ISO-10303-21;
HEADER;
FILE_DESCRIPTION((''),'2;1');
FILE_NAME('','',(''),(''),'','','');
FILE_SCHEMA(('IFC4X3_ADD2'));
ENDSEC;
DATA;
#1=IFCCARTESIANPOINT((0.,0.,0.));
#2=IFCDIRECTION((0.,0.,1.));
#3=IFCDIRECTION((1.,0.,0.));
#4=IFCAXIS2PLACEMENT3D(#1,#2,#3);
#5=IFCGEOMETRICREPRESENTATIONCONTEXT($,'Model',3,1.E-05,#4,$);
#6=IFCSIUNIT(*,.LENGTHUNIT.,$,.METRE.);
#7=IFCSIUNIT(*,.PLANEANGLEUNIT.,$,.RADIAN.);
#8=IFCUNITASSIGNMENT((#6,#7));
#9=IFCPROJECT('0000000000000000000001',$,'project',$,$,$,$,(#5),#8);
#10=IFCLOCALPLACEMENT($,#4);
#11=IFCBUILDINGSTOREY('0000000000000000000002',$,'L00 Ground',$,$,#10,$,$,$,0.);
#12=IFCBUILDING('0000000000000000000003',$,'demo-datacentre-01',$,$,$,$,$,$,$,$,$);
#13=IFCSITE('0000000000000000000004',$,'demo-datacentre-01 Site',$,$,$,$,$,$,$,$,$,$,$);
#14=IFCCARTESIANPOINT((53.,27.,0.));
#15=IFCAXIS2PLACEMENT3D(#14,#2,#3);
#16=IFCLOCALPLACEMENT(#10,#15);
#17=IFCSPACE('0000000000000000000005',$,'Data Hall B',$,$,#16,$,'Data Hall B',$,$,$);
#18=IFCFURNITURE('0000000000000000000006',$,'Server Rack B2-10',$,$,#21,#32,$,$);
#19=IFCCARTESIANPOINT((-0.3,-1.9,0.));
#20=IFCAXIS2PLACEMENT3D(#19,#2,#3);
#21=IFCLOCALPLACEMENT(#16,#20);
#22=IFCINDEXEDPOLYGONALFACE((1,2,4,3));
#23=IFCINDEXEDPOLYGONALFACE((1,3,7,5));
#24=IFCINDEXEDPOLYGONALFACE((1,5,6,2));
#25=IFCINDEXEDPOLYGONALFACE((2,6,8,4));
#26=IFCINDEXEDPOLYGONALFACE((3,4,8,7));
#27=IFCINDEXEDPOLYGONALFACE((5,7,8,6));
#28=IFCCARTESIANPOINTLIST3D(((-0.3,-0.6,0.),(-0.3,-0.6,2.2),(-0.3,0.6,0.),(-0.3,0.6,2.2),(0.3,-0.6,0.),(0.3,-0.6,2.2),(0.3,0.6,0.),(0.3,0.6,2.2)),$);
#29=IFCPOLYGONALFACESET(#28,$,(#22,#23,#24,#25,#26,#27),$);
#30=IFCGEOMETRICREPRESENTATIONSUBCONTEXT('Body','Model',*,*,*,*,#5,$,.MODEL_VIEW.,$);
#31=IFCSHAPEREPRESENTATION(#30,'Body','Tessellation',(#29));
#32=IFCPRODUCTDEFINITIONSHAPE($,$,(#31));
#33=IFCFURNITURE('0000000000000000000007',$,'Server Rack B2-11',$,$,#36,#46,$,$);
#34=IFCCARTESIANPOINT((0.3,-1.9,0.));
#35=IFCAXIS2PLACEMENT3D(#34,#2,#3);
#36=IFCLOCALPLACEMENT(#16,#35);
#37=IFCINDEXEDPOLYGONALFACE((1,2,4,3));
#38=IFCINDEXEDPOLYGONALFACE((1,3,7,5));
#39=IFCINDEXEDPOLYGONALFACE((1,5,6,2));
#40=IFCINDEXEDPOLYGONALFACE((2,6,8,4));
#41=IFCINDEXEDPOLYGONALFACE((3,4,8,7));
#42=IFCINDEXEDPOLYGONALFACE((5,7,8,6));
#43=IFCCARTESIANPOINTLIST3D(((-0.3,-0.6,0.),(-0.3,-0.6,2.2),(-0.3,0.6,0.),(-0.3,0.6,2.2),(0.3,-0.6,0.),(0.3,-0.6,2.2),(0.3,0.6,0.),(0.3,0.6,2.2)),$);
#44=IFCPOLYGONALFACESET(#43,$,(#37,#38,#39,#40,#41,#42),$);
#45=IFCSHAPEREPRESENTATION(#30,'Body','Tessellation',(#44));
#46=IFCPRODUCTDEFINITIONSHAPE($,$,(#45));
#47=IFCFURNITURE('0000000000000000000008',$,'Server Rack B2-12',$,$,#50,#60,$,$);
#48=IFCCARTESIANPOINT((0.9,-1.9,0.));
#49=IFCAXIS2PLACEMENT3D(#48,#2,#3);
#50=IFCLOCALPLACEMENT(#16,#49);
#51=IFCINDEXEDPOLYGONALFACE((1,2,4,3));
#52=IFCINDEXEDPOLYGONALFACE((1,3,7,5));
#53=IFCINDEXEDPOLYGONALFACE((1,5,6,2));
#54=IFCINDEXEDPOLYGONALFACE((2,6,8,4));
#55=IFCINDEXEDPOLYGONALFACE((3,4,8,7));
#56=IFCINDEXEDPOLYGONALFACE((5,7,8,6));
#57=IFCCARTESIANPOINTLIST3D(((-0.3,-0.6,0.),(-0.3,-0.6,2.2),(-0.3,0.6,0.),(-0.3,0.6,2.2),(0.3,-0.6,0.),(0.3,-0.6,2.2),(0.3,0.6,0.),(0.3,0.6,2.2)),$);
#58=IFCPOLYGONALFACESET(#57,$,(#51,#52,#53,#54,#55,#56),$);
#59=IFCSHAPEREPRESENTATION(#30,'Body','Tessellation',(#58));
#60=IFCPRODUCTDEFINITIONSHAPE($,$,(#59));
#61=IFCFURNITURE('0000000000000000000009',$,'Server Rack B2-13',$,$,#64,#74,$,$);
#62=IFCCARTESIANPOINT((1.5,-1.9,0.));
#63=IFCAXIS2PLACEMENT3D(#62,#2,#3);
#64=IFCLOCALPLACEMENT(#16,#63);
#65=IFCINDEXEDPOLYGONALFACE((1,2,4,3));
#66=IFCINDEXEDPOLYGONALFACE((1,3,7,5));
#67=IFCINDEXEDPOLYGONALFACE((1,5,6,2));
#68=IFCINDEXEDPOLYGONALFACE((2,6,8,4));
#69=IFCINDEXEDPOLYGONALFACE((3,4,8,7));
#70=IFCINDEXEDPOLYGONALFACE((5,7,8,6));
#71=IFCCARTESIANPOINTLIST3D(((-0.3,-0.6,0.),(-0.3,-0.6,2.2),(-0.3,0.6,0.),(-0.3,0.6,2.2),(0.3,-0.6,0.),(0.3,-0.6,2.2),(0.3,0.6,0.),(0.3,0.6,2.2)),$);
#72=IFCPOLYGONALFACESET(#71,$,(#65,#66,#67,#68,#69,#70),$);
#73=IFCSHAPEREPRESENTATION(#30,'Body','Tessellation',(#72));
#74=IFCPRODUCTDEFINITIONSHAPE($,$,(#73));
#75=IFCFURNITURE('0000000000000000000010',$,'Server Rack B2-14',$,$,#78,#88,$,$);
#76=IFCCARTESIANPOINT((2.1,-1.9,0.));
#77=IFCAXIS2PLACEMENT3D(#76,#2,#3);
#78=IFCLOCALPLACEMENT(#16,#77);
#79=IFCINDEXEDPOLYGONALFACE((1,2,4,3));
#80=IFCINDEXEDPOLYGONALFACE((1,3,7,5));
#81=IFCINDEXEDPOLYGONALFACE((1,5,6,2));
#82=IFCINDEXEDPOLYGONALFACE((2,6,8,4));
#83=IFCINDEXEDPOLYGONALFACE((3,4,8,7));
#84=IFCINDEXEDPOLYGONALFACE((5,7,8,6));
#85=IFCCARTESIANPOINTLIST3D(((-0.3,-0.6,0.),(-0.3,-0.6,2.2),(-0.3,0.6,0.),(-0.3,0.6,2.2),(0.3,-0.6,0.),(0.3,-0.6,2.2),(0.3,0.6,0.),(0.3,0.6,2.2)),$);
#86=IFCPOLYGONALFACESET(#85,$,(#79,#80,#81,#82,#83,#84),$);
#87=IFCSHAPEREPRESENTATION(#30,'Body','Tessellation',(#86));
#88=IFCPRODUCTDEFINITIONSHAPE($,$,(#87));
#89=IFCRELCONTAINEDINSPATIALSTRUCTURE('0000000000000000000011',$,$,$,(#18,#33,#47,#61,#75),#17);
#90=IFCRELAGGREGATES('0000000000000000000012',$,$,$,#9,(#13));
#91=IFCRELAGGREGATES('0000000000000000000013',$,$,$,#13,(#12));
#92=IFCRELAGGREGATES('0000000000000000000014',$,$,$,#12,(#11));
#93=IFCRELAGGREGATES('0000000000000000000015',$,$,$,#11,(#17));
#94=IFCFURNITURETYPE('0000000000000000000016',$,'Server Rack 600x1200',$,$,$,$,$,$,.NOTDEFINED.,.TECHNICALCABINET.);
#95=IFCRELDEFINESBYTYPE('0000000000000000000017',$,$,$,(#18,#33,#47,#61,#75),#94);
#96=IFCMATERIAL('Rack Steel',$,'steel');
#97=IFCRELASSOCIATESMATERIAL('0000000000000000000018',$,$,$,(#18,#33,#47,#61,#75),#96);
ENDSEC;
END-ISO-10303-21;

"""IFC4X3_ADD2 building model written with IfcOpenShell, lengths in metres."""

from ifc_helpers import new_model, si_unit, frame, origin_with_axes, place, context, subcontext, project, spatial, rectangle, extrude, material, type_object, element, save


model = new_model("IFC4X3_ADD2")

# Units and contexts
model_context = context("Model", 3, precision=1e-05, world=origin_with_axes())
body_context = subcontext(model_context, "Body", "Model", "MODEL_VIEW")
ifc_project = project(units=[si_unit("LENGTHUNIT", "METRE"), si_unit("PLANEANGLEUNIT", "RADIAN")], contexts=[model_context])

# Site, building, storey
site = spatial("IfcSite", under=ifc_project, Name="demo-datacentre-01 Site")
building = spatial("IfcBuilding", under=site, Name="demo-datacentre-01")
storey_placement = place(None, origin_with_axes())
storey = spatial("IfcBuildingStorey", under=building, at=storey_placement, Name="L00 Ground", Elevation=0.0)

# Shared definitions
space_placement = place(storey_placement, frame((53.0, 27.0, 0.0), z_axis=(0.0, 0.0, 1.0), x_axis=(1.0, 0.0, 0.0)))
space = spatial("IfcSpace", under=storey, at=space_placement, Name="Data Hall B", LongName="Data Hall B")

# Furniture
ifc_material_1 = material(Name="Rack Steel", Category="steel")
furniture_type = type_object("IfcFurnitureType", Name="Server Rack 600x1200", AssemblyPlace="NOTDEFINED", PredefinedType="TECHNICALCABINET")
for number, where, z_axis, x_axis, name in (
    (1, (-0.3, -1.9, 0.0), (0.0, 0.0, 1.0), (1.0, 0.0, 0.0), "Server Rack B2-10"),
    (2, (0.3, -1.9, 0.0), (0.0, 0.0, 1.0), (1.0, 0.0, 0.0), "Server Rack B2-11"),
    (3, (0.9, -1.9, 0.0), (0.0, 0.0, 1.0), (1.0, 0.0, 0.0), "Server Rack B2-12"),
    (4, (1.5, -1.9, 0.0), (0.0, 0.0, 1.0), (1.0, 0.0, 0.0), "Server Rack B2-13"),
    (5, (2.1, -1.9, 0.0), (0.0, 0.0, 1.0), (1.0, 0.0, 0.0), "Server Rack B2-14"),
):
    element("IfcFurniture", number, at=place(space_placement, frame(where, z_axis=z_axis, x_axis=x_axis)), inside=space, type_object=furniture_type, material=ifc_material_1, Name=name, context=body_context, shape_type="SweptSolid", body=[
        extrude(rectangle(XDim=0.6, YDim=1.2), origin_with_axes(), (0.0, 0.0, 1.0), 2.2),
    ])

save(model, "model.ifc")
